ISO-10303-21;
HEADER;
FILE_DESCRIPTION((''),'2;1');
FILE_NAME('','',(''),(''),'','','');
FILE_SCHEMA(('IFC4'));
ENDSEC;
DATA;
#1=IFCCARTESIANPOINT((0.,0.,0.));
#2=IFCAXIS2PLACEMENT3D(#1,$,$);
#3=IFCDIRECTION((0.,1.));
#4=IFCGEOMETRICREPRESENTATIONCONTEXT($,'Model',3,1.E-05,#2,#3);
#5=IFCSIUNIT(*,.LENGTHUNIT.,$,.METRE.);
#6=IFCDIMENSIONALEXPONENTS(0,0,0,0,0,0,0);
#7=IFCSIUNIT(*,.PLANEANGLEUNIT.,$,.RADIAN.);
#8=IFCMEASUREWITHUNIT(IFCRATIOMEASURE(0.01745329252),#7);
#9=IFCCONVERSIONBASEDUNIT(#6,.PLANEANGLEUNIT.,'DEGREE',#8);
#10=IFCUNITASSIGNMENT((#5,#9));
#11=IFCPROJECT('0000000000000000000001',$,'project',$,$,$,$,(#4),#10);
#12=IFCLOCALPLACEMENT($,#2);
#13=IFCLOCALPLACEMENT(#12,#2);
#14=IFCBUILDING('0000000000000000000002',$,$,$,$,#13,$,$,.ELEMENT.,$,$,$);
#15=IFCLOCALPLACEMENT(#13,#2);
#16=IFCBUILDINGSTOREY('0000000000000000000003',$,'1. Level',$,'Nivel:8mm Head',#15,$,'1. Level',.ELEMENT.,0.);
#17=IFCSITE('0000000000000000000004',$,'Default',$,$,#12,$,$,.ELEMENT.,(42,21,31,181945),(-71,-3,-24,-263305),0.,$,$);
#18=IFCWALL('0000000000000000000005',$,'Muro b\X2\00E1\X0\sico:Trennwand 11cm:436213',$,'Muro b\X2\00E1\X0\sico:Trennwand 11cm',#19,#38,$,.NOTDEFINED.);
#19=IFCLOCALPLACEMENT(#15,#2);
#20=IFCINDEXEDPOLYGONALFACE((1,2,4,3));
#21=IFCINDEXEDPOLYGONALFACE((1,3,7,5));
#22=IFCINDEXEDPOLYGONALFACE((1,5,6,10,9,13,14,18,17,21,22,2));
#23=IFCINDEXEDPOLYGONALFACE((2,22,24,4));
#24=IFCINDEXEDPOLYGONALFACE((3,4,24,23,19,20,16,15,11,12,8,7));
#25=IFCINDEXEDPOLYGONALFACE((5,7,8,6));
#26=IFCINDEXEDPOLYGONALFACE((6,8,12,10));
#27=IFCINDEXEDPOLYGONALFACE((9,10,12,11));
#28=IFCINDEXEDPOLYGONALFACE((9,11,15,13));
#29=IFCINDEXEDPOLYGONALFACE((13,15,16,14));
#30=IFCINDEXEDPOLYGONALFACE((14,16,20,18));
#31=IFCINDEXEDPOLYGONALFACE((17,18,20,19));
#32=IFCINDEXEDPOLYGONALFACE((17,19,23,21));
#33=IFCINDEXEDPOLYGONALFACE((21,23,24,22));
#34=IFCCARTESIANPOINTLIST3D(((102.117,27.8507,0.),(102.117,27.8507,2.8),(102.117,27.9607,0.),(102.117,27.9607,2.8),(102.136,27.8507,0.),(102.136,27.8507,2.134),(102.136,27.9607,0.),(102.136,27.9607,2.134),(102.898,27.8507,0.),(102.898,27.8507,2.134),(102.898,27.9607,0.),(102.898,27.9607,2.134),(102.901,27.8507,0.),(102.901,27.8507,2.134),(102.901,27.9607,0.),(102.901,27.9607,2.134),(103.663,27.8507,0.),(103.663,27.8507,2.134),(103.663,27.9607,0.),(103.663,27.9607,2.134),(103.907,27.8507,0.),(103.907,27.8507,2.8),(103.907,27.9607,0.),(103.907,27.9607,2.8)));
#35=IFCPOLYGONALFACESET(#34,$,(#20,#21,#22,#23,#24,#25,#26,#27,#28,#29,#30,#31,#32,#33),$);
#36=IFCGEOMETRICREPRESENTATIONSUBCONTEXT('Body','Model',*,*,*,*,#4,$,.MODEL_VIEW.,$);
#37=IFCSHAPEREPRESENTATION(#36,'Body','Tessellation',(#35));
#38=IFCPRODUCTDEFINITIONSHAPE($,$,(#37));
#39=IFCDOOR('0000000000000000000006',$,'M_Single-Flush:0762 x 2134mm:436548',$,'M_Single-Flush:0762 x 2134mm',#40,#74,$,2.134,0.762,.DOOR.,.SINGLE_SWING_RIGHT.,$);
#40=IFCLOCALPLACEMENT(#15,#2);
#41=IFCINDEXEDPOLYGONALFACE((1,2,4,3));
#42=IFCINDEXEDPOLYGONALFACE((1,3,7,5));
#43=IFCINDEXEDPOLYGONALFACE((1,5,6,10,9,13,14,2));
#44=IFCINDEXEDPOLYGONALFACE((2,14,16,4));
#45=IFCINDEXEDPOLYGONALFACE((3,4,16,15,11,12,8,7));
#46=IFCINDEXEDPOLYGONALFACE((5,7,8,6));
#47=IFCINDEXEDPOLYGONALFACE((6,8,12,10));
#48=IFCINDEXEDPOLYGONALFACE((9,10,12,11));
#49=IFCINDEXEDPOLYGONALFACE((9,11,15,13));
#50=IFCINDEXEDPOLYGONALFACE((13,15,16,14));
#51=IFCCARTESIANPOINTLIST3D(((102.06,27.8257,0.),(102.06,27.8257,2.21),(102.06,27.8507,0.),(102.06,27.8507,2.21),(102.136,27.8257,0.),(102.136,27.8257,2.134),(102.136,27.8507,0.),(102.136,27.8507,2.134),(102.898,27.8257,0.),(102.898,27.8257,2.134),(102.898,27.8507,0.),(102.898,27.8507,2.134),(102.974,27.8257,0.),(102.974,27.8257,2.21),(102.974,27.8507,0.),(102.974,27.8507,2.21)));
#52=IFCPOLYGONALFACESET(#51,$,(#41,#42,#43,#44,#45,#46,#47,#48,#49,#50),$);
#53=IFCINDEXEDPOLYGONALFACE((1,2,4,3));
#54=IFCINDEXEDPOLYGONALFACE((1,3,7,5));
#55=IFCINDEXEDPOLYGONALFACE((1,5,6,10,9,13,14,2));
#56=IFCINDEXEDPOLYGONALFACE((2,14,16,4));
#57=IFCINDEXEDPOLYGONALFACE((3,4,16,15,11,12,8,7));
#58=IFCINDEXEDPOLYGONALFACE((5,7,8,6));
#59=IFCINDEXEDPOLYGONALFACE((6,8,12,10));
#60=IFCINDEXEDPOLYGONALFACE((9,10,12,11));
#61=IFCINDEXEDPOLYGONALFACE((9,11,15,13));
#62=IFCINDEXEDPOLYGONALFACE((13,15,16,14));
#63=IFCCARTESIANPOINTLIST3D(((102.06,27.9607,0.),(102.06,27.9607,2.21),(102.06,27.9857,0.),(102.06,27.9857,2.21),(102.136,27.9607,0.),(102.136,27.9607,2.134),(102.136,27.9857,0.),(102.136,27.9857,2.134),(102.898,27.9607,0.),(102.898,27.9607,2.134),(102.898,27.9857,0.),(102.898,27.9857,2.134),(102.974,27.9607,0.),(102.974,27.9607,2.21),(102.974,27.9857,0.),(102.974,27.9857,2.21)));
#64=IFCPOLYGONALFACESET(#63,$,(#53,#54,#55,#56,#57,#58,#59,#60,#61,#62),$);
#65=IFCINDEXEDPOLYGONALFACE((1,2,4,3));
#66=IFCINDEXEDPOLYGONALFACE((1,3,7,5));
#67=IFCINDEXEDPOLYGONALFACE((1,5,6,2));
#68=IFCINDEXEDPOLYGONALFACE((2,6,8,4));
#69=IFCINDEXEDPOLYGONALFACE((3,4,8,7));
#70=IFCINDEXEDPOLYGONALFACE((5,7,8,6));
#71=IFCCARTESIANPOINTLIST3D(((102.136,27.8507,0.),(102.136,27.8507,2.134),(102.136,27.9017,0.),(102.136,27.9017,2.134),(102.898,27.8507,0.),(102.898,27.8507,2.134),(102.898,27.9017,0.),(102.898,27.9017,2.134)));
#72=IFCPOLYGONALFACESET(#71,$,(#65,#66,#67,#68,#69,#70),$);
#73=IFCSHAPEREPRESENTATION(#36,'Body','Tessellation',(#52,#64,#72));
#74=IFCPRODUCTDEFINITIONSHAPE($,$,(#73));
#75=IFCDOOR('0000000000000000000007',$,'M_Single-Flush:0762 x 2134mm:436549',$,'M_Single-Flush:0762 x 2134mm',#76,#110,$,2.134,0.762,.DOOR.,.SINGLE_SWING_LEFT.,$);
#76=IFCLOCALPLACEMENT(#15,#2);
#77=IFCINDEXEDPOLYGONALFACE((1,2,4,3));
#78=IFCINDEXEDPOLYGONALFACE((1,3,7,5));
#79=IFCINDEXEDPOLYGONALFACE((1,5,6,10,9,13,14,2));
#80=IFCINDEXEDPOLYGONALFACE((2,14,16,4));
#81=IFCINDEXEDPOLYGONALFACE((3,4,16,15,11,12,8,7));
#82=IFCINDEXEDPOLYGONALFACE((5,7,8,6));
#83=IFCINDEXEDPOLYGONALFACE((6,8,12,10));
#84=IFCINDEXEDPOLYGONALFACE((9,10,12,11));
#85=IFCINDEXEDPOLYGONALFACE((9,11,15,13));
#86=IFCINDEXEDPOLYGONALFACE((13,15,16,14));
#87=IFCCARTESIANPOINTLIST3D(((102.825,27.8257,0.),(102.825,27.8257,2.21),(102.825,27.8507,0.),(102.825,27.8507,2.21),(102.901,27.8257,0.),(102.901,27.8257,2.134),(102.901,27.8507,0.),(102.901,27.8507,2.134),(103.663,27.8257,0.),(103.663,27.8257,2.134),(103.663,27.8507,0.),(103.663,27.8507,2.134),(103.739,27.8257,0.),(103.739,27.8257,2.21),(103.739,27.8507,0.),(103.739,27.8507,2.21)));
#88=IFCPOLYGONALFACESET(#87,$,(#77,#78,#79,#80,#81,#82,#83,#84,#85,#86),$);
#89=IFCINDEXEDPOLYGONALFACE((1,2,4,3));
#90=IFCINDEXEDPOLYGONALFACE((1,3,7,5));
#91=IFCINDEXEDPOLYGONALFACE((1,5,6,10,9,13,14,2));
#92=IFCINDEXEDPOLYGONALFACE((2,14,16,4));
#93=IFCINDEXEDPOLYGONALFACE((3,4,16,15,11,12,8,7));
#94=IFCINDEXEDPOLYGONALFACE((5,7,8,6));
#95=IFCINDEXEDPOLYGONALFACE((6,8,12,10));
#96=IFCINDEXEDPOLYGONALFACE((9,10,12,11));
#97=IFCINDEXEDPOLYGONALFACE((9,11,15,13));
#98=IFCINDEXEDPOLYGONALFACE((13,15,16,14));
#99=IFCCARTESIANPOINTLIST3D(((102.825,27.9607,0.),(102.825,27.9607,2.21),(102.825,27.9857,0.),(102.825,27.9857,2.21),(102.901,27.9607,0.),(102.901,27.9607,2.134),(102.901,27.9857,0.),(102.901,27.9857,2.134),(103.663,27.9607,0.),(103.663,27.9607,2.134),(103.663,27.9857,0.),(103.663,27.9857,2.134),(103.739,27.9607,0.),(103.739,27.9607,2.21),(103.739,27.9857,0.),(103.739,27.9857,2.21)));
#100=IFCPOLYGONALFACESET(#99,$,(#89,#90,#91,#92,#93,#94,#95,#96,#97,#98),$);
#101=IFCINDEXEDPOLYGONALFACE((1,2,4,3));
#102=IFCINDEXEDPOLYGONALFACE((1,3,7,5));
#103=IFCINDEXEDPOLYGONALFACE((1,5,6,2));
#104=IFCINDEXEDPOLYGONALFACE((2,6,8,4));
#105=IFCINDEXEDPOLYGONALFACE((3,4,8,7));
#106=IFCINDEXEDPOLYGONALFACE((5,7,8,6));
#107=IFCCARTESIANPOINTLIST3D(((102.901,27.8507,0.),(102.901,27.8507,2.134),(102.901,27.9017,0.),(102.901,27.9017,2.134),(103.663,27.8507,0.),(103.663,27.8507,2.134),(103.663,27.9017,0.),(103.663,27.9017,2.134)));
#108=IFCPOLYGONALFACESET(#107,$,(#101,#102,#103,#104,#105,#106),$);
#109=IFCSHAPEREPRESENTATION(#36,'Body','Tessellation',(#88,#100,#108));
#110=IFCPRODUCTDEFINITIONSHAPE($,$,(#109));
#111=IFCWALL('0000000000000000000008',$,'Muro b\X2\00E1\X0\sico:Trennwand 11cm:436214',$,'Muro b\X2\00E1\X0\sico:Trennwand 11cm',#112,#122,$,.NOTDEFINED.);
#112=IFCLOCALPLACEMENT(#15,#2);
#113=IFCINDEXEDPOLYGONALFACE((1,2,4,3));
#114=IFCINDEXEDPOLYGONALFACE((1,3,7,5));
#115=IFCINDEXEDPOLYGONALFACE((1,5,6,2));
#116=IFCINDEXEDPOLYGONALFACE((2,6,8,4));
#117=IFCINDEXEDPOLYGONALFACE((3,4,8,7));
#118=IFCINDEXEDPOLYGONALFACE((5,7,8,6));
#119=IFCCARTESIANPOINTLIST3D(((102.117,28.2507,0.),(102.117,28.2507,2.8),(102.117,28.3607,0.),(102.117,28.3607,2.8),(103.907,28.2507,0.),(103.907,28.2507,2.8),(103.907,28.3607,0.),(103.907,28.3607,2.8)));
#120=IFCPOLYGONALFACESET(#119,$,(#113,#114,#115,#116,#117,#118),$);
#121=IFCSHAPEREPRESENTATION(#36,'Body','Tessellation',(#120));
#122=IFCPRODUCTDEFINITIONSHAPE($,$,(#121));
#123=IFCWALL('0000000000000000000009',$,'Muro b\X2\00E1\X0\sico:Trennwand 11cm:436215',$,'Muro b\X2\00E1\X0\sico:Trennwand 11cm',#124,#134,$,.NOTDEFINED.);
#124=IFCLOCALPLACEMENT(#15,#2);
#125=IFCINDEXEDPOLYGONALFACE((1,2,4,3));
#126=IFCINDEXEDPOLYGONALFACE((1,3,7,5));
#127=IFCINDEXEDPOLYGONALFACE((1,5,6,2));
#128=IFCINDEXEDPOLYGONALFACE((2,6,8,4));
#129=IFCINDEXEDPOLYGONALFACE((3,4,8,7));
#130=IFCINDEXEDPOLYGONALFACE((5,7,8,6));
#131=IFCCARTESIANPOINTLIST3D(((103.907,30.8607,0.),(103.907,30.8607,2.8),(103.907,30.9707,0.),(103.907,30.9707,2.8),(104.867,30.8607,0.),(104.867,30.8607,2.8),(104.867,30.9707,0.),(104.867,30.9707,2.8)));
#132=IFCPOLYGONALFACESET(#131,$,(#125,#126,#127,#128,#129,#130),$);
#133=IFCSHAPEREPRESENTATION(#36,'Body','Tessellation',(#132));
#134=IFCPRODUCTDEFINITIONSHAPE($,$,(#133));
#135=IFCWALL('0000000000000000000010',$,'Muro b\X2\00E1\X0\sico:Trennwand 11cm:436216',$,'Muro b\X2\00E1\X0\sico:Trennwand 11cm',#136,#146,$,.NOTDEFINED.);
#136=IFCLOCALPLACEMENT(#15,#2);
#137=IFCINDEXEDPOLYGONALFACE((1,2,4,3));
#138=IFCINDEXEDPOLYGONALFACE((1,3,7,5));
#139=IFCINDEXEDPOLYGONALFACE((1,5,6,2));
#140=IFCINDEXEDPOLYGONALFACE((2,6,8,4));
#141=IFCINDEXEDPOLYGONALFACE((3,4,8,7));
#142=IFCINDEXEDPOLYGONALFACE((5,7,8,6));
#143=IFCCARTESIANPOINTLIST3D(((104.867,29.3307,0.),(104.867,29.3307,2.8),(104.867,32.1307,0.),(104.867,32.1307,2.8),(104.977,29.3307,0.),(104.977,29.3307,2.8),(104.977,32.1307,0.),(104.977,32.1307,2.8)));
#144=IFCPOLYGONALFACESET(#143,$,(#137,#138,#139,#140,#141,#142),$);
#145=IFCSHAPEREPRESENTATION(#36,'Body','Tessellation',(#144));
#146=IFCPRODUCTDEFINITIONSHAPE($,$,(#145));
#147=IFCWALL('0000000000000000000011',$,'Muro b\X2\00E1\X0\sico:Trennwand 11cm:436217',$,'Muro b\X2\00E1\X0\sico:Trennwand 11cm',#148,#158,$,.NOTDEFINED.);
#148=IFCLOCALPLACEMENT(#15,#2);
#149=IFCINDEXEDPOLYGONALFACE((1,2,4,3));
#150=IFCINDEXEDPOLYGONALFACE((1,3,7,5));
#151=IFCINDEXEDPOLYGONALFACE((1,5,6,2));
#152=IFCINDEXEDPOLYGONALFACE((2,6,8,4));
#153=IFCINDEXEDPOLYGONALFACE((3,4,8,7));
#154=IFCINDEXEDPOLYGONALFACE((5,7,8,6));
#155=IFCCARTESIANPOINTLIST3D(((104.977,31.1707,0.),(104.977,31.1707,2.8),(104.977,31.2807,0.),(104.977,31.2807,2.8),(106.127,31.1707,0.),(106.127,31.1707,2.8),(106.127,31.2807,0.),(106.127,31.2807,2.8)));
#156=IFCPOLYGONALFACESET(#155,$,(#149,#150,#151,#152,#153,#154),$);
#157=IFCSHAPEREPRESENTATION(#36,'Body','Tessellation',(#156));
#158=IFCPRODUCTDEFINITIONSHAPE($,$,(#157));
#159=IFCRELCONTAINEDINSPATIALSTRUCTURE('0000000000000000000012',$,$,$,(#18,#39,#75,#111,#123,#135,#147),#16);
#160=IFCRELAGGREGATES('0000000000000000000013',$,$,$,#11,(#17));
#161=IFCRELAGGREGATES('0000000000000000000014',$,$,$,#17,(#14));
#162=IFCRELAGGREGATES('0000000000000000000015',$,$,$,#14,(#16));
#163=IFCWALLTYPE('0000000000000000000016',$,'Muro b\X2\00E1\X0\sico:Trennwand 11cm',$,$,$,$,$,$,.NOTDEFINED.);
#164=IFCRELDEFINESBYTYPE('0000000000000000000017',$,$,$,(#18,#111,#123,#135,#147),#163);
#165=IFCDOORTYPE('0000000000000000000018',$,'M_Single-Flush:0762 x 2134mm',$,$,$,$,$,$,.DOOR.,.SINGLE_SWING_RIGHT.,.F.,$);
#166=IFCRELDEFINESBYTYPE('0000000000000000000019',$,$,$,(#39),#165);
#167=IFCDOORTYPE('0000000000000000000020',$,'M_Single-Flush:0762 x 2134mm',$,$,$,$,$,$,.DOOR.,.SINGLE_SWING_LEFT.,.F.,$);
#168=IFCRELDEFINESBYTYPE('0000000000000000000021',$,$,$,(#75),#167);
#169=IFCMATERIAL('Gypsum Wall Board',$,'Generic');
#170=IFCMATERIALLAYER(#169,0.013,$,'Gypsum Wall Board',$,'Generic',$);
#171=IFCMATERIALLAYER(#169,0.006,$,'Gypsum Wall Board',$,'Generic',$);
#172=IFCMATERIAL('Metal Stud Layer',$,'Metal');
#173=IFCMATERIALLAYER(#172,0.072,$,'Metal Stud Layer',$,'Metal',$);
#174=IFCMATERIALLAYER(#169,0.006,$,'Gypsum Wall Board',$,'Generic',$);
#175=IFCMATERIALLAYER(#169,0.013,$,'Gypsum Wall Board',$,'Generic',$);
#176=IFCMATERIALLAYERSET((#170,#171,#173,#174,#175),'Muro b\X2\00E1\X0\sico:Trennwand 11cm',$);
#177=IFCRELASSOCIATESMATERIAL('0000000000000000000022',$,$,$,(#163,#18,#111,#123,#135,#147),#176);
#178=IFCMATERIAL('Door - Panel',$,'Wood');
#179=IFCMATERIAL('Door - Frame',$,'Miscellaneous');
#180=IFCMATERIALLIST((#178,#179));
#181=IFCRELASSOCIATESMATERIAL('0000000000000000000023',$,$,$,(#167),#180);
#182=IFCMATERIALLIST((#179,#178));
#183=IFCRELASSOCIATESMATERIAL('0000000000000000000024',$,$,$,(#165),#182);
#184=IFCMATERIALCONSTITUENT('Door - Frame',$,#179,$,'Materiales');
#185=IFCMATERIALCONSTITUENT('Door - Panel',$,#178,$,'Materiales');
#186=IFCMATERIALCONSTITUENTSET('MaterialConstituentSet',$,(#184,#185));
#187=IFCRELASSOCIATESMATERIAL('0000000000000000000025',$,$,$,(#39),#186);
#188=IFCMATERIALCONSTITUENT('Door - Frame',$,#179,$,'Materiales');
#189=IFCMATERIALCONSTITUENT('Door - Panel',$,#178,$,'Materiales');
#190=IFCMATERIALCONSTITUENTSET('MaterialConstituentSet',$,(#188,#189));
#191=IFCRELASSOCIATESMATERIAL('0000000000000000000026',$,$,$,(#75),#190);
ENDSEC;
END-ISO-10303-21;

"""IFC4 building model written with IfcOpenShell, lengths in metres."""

from ifc_helpers import new_model, entity, si_unit, converted_unit, direction, frame, frame_2d, origin, origin_2d_with_axis, place, context, subcontext, project, spatial, polyline, rectangle, outline, extrude, source, transform, mapped, material, material_list, layer, layer_set, layer_usage, constituent, constituent_set, type_object, type_shapes, element, fill, save


model = new_model("IFC4")

# Units and contexts
model_context = context("Model", 3, precision=1e-05, world=origin(), true_north=direction((0.0, 1.0)))
body_context = subcontext(model_context, "Body", "Model", "MODEL_VIEW")
ifc_project = project(units=[si_unit("LENGTHUNIT", "METRE"), converted_unit("PLANEANGLEUNIT", "DEGREE", entity("IfcRatioMeasure", 0.01745329252), si_unit("PLANEANGLEUNIT", "RADIAN"), dimensions=[0, 0, 0, 0, 0, 0, 0])], contexts=[model_context])

# Site, building, storey
site_placement = place(None, origin())
site = spatial("IfcSite", under=ifc_project, at=site_placement, Name="Default", CompositionType="ELEMENT", RefLatitude=(42, 21, 31, 181945), RefLongitude=(-71, -3, -24, -263305), RefElevation=0.0)
building_placement = place(site_placement, origin())
building = spatial("IfcBuilding", under=site, at=building_placement, CompositionType="ELEMENT")
storey_placement = place(building_placement, origin())
storey = spatial("IfcBuildingStorey", under=building, at=storey_placement, Name="1. Level", ObjectType="Nivel:8mm Head", LongName="1. Level", CompositionType="ELEMENT", Elevation=0.0)

# Shared definitions
ifc_material_1 = material(Name="Gypsum Wall Board", Category="Generic")
ifc_layer_1 = layer(ifc_material_1, 0.013, Name="Gypsum Wall Board", Category="Generic")
ifc_layer_2 = layer(ifc_material_1, 0.006, Name="Gypsum Wall Board", Category="Generic")
ifc_material_2 = material(Name="Metal Stud Layer", Category="Metal")
ifc_layer_3 = layer(ifc_material_2, 0.072, Name="Metal Stud Layer", Category="Metal")
ifc_layer_4 = layer(ifc_material_1, 0.006, Name="Gypsum Wall Board", Category="Generic")
ifc_layer_5 = layer(ifc_material_1, 0.013, Name="Gypsum Wall Board", Category="Generic")
ifc_layer_set_1 = layer_set([ifc_layer_1, ifc_layer_2, ifc_layer_3, ifc_layer_4, ifc_layer_5], Name="Muro básico:Trennwand 11cm")
wall_type_1 = type_object("IfcWallType", Name="Muro básico:Trennwand 11cm", PredefinedType="NOTDEFINED", material=ifc_layer_set_1)
ifc_material_3 = material(Name="Door - Frame", Category="Miscellaneous")
ifc_material_4 = material(Name="Door - Panel", Category="Wood")
ifc_material_list_1 = material_list([ifc_material_4, ifc_material_3])
door_type_1 = type_object("IfcDoorType", Name="M_Single-Flush:0762 x 2134mm", OperationType="SINGLE_SWING_LEFT", ParameterTakesPrecedence=False, PredefinedType="DOOR", material=ifc_material_list_1)
shared_shape_1 = source(origin(), body_context, "Body", "SweptSolid", [
    extrude(outline(polyline([(-0.457, -1.124), (0.457, -1.124), (0.457, 1.086), (0.381, 1.086), (0.381, -1.048), (-0.381, -1.048), (-0.381, 1.086), (-0.457, 1.086), (-0.457, -1.124)])), frame((0.381, 0.135, 1.086), z_axis=(0.0, -1.0, 0.0), x_axis=(-1.0, 0.0, 0.0)), (0.0, 0.0, 1.0), 0.025),
    extrude(outline(polyline([(-1.124, -0.457), (1.086, -0.457), (1.086, -0.381), (-1.048, -0.381), (-1.048, 0.381), (1.086, 0.381), (1.086, 0.457), (-1.124, 0.457), (-1.124, -0.457)])), frame((0.381, 0.0, 1.086), z_axis=(0.0, -1.0, 0.0), x_axis=(0.0, 0.0, -1.0)), (0.0, 0.0, 1.0), 0.025),
    extrude(rectangle(XDim=0.762, YDim=0.051, at=origin_2d_with_axis()), frame((0.381, 0.0845, 0.0)), (0.0, 0.0, 1.0), 2.134),
])
type_shapes(door_type_1, [shared_shape_1])

# Wall, openings, doors
ifc_layer_usage_1 = layer_usage(ifc_layer_set_1, "AXIS2", "NEGATIVE", 0.055)
wall_1_placement = place(storey_placement, frame((103.907, 27.9057, 0.0), z_axis=(0.0, 0.0, 1.0), x_axis=(-1.0, 0.0, 0.0)))
wall_1 = element("IfcWall", 1, at=wall_1_placement, inside=storey, type_object=wall_type_1, material=ifc_layer_usage_1, Name="Muro básico:Trennwand 11cm:436213", ObjectType="Muro básico:Trennwand 11cm", PredefinedType="NOTDEFINED", context=body_context, shape_type="SweptSolid", body=[
    extrude(rectangle(XDim=1.79, YDim=0.11, at=frame_2d((0.895, 0.0), x_axis=(-1.0, 0.0))), origin(), (0.0, 0.0, 1.0), 2.8),
])
opening_1_placement = place(wall_1_placement, frame((1.009, -0.055, 0.0)))
opening_1 = element("IfcOpeningElement", 2, at=opening_1_placement, cuts=wall_1, ObjectType="Opening", PredefinedType="OPENING", context=body_context, shape_type="SweptSolid", body=[
    extrude(rectangle(XDim=0.762, YDim=2.134, at=frame_2d((1.067, 0.381), x_axis=(0.0, 1.0))), frame((0.0, 0.0, 0.0), z_axis=(0.0, 1.0, 0.0), x_axis=(0.0, 0.0, 1.0)), (0.0, 0.0, 1.0), 0.11),
])
opening_2_placement = place(wall_1_placement, frame((0.244, -0.055, 0.0)))
opening_2 = element("IfcOpeningElement", 3, at=opening_2_placement, cuts=wall_1, ObjectType="Opening", PredefinedType="OPENING", context=body_context, shape_type="SweptSolid", body=[
    extrude(rectangle(XDim=0.762, YDim=2.134, at=frame_2d((1.067, 0.381), x_axis=(0.0, -1.0))), frame((0.0, 0.0, 0.0), z_axis=(0.0, 1.0, 0.0), x_axis=(0.0, 0.0, 1.0)), (0.0, 0.0, 1.0), 0.11),
])
ifc_constituent_1 = constituent(ifc_material_3, Name="Door - Frame", Category="Materiales")
ifc_constituent_2 = constituent(ifc_material_4, Name="Door - Panel", Category="Materiales")
ifc_constituent_set_1 = constituent_set(constituents=[ifc_constituent_1, ifc_constituent_2], Name="MaterialConstituentSet")
ifc_material_list_2 = material_list([ifc_material_3, ifc_material_4])
door_type_2 = type_object("IfcDoorType", Name="M_Single-Flush:0762 x 2134mm", OperationType="SINGLE_SWING_RIGHT", ParameterTakesPrecedence=False, PredefinedType="DOOR", material=ifc_material_list_2)
shared_shape_2 = source(origin(), body_context, "Body", "SweptSolid", [
    extrude(outline(polyline([(-0.457, -1.124), (0.457, -1.124), (0.457, 1.086), (0.381, 1.086), (0.381, -1.048), (-0.381, -1.048), (-0.381, 1.086), (-0.457, 1.086), (-0.457, -1.124)])), frame((0.381, 0.11, 1.086), z_axis=(0.0, 1.0, 0.0), x_axis=(1.0, 0.0, 0.0)), (0.0, 0.0, 1.0), 0.025),
    extrude(outline(polyline([(-1.124, -0.457), (1.086, -0.457), (1.086, -0.381), (-1.048, -0.381), (-1.048, 0.381), (1.086, 0.381), (1.086, 0.457), (-1.124, 0.457), (-1.124, -0.457)])), frame((0.381, -0.025, 1.086), z_axis=(0.0, 1.0, 0.0), x_axis=(0.0, 0.0, -1.0)), (0.0, 0.0, 1.0), 0.025),
    extrude(rectangle(XDim=0.051, YDim=0.762, at=origin_2d_with_axis()), frame((0.381, 0.0845, 0.0), z_axis=(0.0, 0.0, 1.0), x_axis=(0.0, 1.0, 0.0)), (0.0, 0.0, 1.0), 2.134),
])
type_shapes(door_type_2, [shared_shape_2])
door_1_placement = place(opening_1_placement, origin())
door_1 = element("IfcDoor", 4, at=door_1_placement, inside=storey, type_object=door_type_2, material=ifc_constituent_set_1, Name="M_Single-Flush:0762 x 2134mm:436548", ObjectType="M_Single-Flush:0762 x 2134mm", OperationType="SINGLE_SWING_RIGHT", OverallHeight=2.134, OverallWidth=0.762, PredefinedType="DOOR", context=body_context, shape_type="MappedRepresentation", body=[
    mapped(shared_shape_2, transform((0.0, 0.0, 0.0), scale=1.0)),
])
fill(opening_1, door_1)
ifc_constituent_3 = constituent(ifc_material_3, Name="Door - Frame", Category="Materiales")
ifc_constituent_4 = constituent(ifc_material_4, Name="Door - Panel", Category="Materiales")
ifc_constituent_set_2 = constituent_set(constituents=[ifc_constituent_3, ifc_constituent_4], Name="MaterialConstituentSet")
door_2_placement = place(opening_2_placement, origin())
door_2 = element("IfcDoor", 5, at=door_2_placement, inside=storey, type_object=door_type_1, material=ifc_constituent_set_2, Name="M_Single-Flush:0762 x 2134mm:436549", ObjectType="M_Single-Flush:0762 x 2134mm", OperationType="SINGLE_SWING_LEFT", OverallHeight=2.134, OverallWidth=0.762, PredefinedType="DOOR", context=body_context, shape_type="MappedRepresentation", body=[
    mapped(shared_shape_1, transform((0.0, 0.0, 0.0), scale=1.0)),
])
fill(opening_2, door_2)

# Walls
ifc_layer_usage_2 = layer_usage(ifc_layer_set_1, "AXIS2", "NEGATIVE", 0.055)
wall_2_placement = place(storey_placement, frame((103.907, 28.3057, 0.0), z_axis=(0.0, 0.0, 1.0), x_axis=(-1.0, 0.0, 0.0)))
element("IfcWall", 6, at=wall_2_placement, inside=storey, type_object=wall_type_1, material=ifc_layer_usage_2, Name="Muro básico:Trennwand 11cm:436214", ObjectType="Muro básico:Trennwand 11cm", PredefinedType="NOTDEFINED", context=body_context, shape_type="SweptSolid", body=[
    extrude(rectangle(XDim=1.79, YDim=0.11, at=frame_2d((0.895, 0.0), x_axis=(-1.0, 0.0))), origin(), (0.0, 0.0, 1.0), 2.8),
])
ifc_layer_usage_3 = layer_usage(ifc_layer_set_1, "AXIS2", "NEGATIVE", 0.055)
wall_3_placement = place(storey_placement, frame((104.867, 30.9157, 0.0), z_axis=(0.0, 0.0, 1.0), x_axis=(-1.0, 0.0, 0.0)))
element("IfcWall", 7, at=wall_3_placement, inside=storey, type_object=wall_type_1, material=ifc_layer_usage_3, Name="Muro básico:Trennwand 11cm:436215", ObjectType="Muro básico:Trennwand 11cm", PredefinedType="NOTDEFINED", context=body_context, shape_type="SweptSolid", body=[
    extrude(rectangle(XDim=0.96, YDim=0.11, at=frame_2d((0.48, 0.0), x_axis=(-1.0, 0.0))), origin(), (0.0, 0.0, 1.0), 2.8),
])
ifc_layer_usage_4 = layer_usage(ifc_layer_set_1, "AXIS2", "NEGATIVE", 0.055)
wall_4_placement = place(storey_placement, frame((104.922, 32.1307, 0.0), z_axis=(0.0, 0.0, 1.0), x_axis=(0.0, -1.0, 0.0)))
element("IfcWall", 8, at=wall_4_placement, inside=storey, type_object=wall_type_1, material=ifc_layer_usage_4, Name="Muro básico:Trennwand 11cm:436216", ObjectType="Muro básico:Trennwand 11cm", PredefinedType="NOTDEFINED", context=body_context, shape_type="SweptSolid", body=[
    extrude(rectangle(XDim=2.8, YDim=0.11, at=frame_2d((1.4, 0.0), x_axis=(-1.0, 0.0))), origin(), (0.0, 0.0, 1.0), 2.8),
])
ifc_layer_usage_5 = layer_usage(ifc_layer_set_1, "AXIS2", "NEGATIVE", 0.055)
wall_5_placement = place(storey_placement, frame((104.977, 31.2257, 0.0)))
element("IfcWall", 9, at=wall_5_placement, inside=storey, type_object=wall_type_1, material=ifc_layer_usage_5, Name="Muro básico:Trennwand 11cm:436217", ObjectType="Muro básico:Trennwand 11cm", PredefinedType="NOTDEFINED", context=body_context, shape_type="SweptSolid", body=[
    extrude(rectangle(XDim=1.15, YDim=0.11, at=frame_2d((0.575, 0.0), x_axis=(-1.0, 0.0))), origin(), (0.0, 0.0, 1.0), 2.8),
])

save(model, "model.ifc")
